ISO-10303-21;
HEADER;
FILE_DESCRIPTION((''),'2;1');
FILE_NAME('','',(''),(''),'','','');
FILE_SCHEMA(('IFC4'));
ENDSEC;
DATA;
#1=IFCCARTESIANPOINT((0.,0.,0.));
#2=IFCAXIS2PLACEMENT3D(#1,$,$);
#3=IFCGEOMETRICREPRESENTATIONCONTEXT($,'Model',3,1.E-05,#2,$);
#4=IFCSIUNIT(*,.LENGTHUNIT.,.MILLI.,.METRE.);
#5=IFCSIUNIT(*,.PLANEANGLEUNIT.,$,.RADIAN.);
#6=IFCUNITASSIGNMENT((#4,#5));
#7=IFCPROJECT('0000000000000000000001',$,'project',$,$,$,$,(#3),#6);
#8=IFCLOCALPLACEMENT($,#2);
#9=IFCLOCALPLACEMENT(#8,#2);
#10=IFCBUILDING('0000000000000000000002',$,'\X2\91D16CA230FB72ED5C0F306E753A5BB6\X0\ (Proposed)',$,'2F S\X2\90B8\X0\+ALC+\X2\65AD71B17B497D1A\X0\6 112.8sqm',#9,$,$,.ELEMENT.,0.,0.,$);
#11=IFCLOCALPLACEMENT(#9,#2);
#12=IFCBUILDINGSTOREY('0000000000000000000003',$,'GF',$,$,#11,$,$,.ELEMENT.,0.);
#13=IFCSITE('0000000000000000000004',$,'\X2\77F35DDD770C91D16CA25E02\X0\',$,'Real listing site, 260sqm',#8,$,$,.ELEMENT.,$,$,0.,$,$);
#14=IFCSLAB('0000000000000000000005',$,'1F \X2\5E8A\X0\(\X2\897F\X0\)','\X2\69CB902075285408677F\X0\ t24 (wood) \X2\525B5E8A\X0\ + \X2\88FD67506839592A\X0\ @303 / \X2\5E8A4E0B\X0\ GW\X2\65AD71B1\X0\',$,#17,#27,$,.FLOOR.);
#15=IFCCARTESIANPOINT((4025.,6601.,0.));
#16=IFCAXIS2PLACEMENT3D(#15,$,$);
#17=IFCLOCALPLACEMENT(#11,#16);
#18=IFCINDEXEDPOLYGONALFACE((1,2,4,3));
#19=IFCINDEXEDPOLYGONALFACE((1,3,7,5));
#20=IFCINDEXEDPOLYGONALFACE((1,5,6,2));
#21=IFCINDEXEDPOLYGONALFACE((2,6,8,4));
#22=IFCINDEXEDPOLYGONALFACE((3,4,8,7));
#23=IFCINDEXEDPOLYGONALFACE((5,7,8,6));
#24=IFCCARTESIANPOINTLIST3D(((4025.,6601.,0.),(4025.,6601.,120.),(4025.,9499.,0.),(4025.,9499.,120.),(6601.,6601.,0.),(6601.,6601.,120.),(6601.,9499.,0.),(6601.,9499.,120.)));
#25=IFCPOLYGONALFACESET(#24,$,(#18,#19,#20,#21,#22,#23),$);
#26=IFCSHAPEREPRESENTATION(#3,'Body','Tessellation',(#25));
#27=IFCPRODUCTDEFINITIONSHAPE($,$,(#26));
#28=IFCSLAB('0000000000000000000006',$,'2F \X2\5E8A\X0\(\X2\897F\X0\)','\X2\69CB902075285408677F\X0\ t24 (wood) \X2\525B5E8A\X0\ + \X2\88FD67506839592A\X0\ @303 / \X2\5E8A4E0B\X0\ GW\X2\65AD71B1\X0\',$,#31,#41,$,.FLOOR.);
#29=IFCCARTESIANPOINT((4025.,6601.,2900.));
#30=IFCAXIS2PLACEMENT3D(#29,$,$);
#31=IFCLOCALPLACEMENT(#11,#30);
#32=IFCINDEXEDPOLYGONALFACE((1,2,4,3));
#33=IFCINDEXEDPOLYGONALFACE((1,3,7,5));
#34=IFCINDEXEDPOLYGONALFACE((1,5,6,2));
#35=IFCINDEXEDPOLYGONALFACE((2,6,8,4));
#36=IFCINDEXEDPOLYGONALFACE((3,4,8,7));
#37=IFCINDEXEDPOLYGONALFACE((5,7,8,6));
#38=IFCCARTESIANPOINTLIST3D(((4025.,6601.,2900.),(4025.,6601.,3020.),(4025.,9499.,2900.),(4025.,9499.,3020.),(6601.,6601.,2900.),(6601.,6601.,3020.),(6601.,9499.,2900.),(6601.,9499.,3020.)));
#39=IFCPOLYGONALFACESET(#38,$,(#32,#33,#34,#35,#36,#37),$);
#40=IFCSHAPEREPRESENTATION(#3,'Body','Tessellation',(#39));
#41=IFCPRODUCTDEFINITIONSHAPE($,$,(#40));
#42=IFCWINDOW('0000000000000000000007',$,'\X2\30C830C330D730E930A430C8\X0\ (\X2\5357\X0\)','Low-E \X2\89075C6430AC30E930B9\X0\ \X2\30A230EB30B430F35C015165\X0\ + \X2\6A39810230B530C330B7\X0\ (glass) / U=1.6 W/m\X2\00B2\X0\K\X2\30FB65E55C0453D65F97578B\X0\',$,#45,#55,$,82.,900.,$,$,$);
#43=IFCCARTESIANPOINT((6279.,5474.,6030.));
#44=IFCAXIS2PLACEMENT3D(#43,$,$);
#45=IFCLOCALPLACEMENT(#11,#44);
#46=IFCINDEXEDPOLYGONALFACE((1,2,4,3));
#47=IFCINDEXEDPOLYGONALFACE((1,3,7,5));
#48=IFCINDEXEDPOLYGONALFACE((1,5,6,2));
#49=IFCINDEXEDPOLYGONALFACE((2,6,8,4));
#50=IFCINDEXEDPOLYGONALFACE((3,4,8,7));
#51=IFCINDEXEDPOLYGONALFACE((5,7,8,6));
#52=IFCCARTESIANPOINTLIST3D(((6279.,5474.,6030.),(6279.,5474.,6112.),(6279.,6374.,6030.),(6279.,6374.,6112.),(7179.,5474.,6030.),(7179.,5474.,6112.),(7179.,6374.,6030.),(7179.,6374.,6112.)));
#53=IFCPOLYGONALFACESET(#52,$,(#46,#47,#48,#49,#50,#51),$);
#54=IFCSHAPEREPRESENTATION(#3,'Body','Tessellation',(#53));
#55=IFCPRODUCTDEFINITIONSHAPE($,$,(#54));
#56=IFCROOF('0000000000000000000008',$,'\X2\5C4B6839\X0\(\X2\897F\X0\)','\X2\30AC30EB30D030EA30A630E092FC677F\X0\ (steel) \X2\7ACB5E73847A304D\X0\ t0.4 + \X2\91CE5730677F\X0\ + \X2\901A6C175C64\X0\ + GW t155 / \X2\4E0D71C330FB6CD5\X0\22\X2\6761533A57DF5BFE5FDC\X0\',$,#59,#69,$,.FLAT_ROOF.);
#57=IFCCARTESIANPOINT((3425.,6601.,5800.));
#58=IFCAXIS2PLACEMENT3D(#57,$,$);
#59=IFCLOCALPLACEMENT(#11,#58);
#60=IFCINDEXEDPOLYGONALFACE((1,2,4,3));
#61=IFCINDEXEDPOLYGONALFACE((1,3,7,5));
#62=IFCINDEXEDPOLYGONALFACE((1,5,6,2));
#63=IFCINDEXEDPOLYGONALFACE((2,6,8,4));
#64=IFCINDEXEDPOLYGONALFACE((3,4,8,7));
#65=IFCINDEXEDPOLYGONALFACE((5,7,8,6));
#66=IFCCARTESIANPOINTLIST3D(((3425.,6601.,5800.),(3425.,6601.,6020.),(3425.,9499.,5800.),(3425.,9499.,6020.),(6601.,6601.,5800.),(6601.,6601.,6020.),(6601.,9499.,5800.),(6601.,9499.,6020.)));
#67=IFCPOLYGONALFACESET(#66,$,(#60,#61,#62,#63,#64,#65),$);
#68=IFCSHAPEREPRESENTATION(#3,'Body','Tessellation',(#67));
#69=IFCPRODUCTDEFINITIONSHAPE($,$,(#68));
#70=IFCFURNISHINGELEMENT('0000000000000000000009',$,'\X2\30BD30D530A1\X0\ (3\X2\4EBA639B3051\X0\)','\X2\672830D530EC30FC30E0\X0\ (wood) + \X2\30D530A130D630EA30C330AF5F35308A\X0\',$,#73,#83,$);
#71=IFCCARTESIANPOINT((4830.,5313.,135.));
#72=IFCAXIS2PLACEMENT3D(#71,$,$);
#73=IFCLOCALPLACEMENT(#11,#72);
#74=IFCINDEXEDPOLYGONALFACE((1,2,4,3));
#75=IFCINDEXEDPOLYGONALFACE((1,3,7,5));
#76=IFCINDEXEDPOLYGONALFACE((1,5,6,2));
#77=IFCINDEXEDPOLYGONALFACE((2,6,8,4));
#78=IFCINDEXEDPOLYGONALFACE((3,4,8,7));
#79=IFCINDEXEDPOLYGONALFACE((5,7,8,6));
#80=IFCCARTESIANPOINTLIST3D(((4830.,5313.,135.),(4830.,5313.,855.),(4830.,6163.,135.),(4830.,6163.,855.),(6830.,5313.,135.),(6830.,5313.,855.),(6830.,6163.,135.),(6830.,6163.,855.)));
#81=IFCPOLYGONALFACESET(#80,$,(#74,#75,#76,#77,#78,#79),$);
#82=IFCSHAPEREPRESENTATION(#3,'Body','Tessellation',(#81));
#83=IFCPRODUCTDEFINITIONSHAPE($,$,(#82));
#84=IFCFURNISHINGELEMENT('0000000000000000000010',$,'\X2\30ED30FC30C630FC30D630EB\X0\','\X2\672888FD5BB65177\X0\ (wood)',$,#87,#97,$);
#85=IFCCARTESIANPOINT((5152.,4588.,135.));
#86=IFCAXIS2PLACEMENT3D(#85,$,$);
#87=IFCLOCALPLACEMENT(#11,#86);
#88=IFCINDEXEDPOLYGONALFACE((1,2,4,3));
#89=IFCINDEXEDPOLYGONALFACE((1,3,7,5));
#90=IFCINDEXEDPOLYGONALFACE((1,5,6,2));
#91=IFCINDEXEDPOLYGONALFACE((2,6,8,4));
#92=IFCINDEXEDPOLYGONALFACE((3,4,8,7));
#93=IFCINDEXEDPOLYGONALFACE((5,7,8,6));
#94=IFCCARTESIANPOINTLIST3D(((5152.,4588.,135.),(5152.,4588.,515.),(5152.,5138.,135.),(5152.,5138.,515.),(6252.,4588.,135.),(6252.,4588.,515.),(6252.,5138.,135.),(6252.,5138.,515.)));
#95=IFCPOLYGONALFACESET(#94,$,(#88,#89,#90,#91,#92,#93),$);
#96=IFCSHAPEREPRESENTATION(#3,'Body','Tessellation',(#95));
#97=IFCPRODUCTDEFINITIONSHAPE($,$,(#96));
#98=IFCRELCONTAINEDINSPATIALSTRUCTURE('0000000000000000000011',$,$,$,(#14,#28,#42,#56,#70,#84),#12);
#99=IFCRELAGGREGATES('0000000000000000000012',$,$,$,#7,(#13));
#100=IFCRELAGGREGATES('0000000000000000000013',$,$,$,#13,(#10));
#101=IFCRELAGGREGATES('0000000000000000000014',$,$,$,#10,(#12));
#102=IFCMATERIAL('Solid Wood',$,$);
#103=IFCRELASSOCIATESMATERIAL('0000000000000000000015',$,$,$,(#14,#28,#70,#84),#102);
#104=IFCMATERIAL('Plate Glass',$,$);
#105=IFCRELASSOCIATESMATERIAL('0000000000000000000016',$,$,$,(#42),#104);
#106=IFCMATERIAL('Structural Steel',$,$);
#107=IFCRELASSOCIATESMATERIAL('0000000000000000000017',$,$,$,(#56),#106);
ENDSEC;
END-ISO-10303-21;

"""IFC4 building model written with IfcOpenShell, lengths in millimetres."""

from ifc_helpers import new_model, si_unit, frame, frame_2d, origin, place, context, project, spatial, rectangle, extrude, material, element, save


model = new_model("IFC4")

# Units and contexts
model_context = context("Model", 3, precision=1e-05, world=origin())
ifc_project = project(units=[si_unit("LENGTHUNIT", "METRE", prefix="MILLI"), si_unit("PLANEANGLEUNIT", "RADIAN")], contexts=[model_context])

# Site, building, storey
site_placement = place(None, origin())
site = spatial("IfcSite", under=ifc_project, at=site_placement, Name="石川県金沢市", ObjectType="Real listing site, 260sqm", CompositionType="ELEMENT", RefElevation=0.0)
building_placement = place(site_placement, origin())
building = spatial("IfcBuilding", under=site, at=building_placement, Name="金沢・狭小の町家 (Proposed)", ObjectType="2F S邸+ALC+断熱等級6 112.8sqm", CompositionType="ELEMENT", ElevationOfRefHeight=0.0, ElevationOfTerrain=0.0)
storey_placement = place(building_placement, origin())
storey = spatial("IfcBuildingStorey", under=building, at=storey_placement, Name="GF", CompositionType="ELEMENT", Elevation=0.0)

# Shared definitions
ifc_material_1 = material(Name="Solid Wood")

# Slabs
slab_1_placement = place(storey_placement, frame((4025.0, 6601.0, 0.0)))
element("IfcSlab", 1, at=slab_1_placement, inside=storey, material=ifc_material_1, Name="1F 床(西)", Description="構造用合板 t24 (wood) 剛床 + 製材根太 @303 / 床下 GW断熱", PredefinedType="FLOOR", context=model_context, shape_type="SweptSolid", body=[
    extrude(rectangle(XDim=2576.0, YDim=2898.0, at=frame_2d((1288.0, 1449.0))), frame((4025.0, 6601.0, 0.0)), (0.0, 0.0, 1.0), 120.0),
])
slab_2_placement = place(storey_placement, frame((4025.0, 6601.0, 2900.0)))
element("IfcSlab", 2, at=slab_2_placement, inside=storey, material=ifc_material_1, Name="2F 床(西)", Description="構造用合板 t24 (wood) 剛床 + 製材根太 @303 / 床下 GW断熱", PredefinedType="FLOOR", context=model_context, shape_type="SweptSolid", body=[
    extrude(rectangle(XDim=2576.0, YDim=2898.0, at=frame_2d((1288.0, 1449.0))), frame((4025.0, 6601.0, 2900.0)), (0.0, 0.0, 1.0), 120.0),
])

# Window
ifc_material_2 = material(Name="Plate Glass")
window_placement = place(storey_placement, frame((6279.0, 5474.0, 6030.0)))
element("IfcWindow", 3, at=window_placement, inside=storey, material=ifc_material_2, Name="トップライト (南)", Description="Low-E 複層ガラス アルゴン封入 + 樹脂サッシ (glass) / U=1.6 W/m²K・日射取得型", OverallHeight=82.0, OverallWidth=900.0, context=model_context, shape_type="SweptSolid", body=[
    extrude(rectangle(XDim=900.0, YDim=900.0, at=frame_2d((450.0, 450.0))), frame((6279.0, 5474.0, 6030.0)), (0.0, 0.0, 1.0), 82.0),
])

# Roof
ifc_material_3 = material(Name="Structural Steel")
for number, where, name in (
    (4, (3425.0, 6601.0, 5800.0), "屋根(西)"),
):
    element("IfcRoof", number, at=place(storey_placement, frame(where)), inside=storey, material=ifc_material_3, Name=name, Description="ガルバリウム鋼板 (steel) 立平葺き t0.4 + 野地板 + 通気層 + GW t155 / 不燃・法22条区域対応", PredefinedType="FLAT_ROOF", context=model_context, shape_type="SweptSolid", body=[
        extrude(rectangle(XDim=3176.0, YDim=2898.0, at=frame_2d((1588.0, 1449.0))), frame((3425.0, 6601.0, 5800.0)), (0.0, 0.0, 1.0), 220.0),
    ])

# Furnishing elements
furnishing_1_placement = place(storey_placement, frame((4830.0, 5313.0, 135.0)))
element("IfcFurnishingElement", 5, at=furnishing_1_placement, inside=storey, material=ifc_material_1, Name="ソファ (3人掛け)", Description="木フレーム (wood) + ファブリック張り", context=model_context, shape_type="SweptSolid", body=[
    extrude(rectangle(XDim=2000.0, YDim=850.0, at=frame_2d((1000.0, 425.0))), frame((4830.0, 5313.0, 135.0)), (0.0, 0.0, 1.0), 720.0),
])
furnishing_2_placement = place(storey_placement, frame((5152.0, 4588.0, 135.0)))
element("IfcFurnishingElement", 6, at=furnishing_2_placement, inside=storey, material=ifc_material_1, Name="ローテーブル", Description="木製家具 (wood)", context=model_context, shape_type="SweptSolid", body=[
    extrude(rectangle(XDim=1100.0, YDim=550.0, at=frame_2d((550.0, 275.0))), frame((5152.0, 4588.0, 135.0)), (0.0, 0.0, 1.0), 380.0),
])

save(model, "model.ifc")
